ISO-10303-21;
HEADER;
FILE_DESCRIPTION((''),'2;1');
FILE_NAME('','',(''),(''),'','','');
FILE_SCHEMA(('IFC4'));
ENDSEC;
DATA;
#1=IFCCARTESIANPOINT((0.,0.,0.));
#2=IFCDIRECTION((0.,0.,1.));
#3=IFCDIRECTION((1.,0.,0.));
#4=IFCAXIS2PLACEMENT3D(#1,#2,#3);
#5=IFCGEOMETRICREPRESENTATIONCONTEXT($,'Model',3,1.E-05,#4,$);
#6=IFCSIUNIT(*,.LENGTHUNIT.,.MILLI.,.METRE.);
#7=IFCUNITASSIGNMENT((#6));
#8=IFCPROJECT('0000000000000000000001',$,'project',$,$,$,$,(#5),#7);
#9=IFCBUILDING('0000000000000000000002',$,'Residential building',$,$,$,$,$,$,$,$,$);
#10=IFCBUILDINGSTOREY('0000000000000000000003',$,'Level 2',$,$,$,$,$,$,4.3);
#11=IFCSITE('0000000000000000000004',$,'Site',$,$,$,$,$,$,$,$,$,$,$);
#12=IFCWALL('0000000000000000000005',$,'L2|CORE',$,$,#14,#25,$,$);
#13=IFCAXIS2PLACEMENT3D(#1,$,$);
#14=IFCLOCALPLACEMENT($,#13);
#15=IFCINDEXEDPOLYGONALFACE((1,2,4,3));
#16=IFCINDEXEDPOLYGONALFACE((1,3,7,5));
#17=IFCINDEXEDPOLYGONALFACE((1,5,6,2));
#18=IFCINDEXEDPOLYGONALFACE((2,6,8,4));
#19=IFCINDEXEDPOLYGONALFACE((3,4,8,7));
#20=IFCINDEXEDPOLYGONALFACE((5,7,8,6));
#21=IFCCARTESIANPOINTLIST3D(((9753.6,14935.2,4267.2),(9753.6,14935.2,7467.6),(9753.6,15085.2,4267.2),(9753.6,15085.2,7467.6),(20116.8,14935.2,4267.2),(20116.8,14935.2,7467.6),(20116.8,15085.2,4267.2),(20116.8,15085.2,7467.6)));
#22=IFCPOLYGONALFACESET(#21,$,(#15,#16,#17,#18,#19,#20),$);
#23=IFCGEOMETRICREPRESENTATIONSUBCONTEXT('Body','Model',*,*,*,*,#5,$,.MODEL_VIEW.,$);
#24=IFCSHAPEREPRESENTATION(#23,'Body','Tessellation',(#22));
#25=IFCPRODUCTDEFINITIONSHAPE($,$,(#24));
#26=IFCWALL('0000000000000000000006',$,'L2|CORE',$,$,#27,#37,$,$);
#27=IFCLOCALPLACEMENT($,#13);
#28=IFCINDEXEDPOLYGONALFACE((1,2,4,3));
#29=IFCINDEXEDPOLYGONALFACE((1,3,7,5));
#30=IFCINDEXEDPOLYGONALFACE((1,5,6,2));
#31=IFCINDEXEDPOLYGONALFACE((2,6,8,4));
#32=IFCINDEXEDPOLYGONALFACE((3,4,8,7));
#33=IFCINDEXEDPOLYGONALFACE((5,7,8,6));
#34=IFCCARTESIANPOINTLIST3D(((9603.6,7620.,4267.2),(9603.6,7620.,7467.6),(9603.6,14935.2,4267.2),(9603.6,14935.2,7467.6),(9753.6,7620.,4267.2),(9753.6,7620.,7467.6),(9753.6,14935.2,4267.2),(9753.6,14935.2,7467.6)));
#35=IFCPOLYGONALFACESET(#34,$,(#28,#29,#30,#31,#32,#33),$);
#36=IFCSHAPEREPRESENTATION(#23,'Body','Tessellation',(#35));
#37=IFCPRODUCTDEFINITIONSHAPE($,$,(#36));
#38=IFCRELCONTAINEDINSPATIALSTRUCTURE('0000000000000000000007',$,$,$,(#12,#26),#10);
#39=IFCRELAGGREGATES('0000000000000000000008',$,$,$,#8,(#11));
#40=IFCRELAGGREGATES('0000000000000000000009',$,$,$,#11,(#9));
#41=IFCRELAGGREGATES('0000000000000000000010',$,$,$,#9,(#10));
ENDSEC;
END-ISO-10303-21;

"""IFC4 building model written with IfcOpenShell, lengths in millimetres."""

from ifc_helpers import new_model, si_unit, frame, origin_with_axes, place, context, subcontext, project, spatial, indexed_curve, outline, extrude, element, save


model = new_model("IFC4")

# Units and contexts
model_context = context("Model", 3, precision=1e-05, world=origin_with_axes())
body_context = subcontext(model_context, "Body", "Model", "MODEL_VIEW")
ifc_project = project(units=[si_unit("LENGTHUNIT", "METRE", prefix="MILLI")], contexts=[model_context])

# Site, building, storey
site = spatial("IfcSite", under=ifc_project, Name="Site")
building = spatial("IfcBuilding", under=site, Name="Residential building")
storey = spatial("IfcBuildingStorey", under=building, Name="Level 2", Elevation=4.3)

# Walls
for number, where, z_axis, x_axis, name in (
    (1, (9753.6, 14935.2, 4267.2), (0.0, 0.0, 1.0), (1.0, 0.0, 0.0), "L2|CORE"),
):
    element("IfcWall", number, at=place(None, frame(where, z_axis=z_axis, x_axis=x_axis)), inside=storey, Name=name, context=body_context, shape_type="SweptSolid", body=[
        extrude(outline(indexed_curve([(0.0, 0.0), (0.0, 150.0), (10363.2, 150.0), (10363.2, 0.0), (0.0, 0.0)], self_intersect=False)), origin_with_axes(), (0.0, 0.0, 1.0), 3200.4),
    ])
wall_1_placement = place(None, frame((9753.6, 7620.0, 4267.2), z_axis=(0.0, 0.0, 1.0), x_axis=(0.0, 1.0, 0.0)))
element("IfcWall", 2, at=wall_1_placement, inside=storey, Name="L2|CORE", context=body_context, shape_type="SweptSolid", body=[
    extrude(outline(indexed_curve([(0.0, 0.0), (0.0, 150.0), (7315.2, 150.0), (7315.2, 0.0), (0.0, 0.0)], self_intersect=False)), origin_with_axes(), (0.0, 0.0, 1.0), 3200.4),
])

save(model, "model.ifc")
